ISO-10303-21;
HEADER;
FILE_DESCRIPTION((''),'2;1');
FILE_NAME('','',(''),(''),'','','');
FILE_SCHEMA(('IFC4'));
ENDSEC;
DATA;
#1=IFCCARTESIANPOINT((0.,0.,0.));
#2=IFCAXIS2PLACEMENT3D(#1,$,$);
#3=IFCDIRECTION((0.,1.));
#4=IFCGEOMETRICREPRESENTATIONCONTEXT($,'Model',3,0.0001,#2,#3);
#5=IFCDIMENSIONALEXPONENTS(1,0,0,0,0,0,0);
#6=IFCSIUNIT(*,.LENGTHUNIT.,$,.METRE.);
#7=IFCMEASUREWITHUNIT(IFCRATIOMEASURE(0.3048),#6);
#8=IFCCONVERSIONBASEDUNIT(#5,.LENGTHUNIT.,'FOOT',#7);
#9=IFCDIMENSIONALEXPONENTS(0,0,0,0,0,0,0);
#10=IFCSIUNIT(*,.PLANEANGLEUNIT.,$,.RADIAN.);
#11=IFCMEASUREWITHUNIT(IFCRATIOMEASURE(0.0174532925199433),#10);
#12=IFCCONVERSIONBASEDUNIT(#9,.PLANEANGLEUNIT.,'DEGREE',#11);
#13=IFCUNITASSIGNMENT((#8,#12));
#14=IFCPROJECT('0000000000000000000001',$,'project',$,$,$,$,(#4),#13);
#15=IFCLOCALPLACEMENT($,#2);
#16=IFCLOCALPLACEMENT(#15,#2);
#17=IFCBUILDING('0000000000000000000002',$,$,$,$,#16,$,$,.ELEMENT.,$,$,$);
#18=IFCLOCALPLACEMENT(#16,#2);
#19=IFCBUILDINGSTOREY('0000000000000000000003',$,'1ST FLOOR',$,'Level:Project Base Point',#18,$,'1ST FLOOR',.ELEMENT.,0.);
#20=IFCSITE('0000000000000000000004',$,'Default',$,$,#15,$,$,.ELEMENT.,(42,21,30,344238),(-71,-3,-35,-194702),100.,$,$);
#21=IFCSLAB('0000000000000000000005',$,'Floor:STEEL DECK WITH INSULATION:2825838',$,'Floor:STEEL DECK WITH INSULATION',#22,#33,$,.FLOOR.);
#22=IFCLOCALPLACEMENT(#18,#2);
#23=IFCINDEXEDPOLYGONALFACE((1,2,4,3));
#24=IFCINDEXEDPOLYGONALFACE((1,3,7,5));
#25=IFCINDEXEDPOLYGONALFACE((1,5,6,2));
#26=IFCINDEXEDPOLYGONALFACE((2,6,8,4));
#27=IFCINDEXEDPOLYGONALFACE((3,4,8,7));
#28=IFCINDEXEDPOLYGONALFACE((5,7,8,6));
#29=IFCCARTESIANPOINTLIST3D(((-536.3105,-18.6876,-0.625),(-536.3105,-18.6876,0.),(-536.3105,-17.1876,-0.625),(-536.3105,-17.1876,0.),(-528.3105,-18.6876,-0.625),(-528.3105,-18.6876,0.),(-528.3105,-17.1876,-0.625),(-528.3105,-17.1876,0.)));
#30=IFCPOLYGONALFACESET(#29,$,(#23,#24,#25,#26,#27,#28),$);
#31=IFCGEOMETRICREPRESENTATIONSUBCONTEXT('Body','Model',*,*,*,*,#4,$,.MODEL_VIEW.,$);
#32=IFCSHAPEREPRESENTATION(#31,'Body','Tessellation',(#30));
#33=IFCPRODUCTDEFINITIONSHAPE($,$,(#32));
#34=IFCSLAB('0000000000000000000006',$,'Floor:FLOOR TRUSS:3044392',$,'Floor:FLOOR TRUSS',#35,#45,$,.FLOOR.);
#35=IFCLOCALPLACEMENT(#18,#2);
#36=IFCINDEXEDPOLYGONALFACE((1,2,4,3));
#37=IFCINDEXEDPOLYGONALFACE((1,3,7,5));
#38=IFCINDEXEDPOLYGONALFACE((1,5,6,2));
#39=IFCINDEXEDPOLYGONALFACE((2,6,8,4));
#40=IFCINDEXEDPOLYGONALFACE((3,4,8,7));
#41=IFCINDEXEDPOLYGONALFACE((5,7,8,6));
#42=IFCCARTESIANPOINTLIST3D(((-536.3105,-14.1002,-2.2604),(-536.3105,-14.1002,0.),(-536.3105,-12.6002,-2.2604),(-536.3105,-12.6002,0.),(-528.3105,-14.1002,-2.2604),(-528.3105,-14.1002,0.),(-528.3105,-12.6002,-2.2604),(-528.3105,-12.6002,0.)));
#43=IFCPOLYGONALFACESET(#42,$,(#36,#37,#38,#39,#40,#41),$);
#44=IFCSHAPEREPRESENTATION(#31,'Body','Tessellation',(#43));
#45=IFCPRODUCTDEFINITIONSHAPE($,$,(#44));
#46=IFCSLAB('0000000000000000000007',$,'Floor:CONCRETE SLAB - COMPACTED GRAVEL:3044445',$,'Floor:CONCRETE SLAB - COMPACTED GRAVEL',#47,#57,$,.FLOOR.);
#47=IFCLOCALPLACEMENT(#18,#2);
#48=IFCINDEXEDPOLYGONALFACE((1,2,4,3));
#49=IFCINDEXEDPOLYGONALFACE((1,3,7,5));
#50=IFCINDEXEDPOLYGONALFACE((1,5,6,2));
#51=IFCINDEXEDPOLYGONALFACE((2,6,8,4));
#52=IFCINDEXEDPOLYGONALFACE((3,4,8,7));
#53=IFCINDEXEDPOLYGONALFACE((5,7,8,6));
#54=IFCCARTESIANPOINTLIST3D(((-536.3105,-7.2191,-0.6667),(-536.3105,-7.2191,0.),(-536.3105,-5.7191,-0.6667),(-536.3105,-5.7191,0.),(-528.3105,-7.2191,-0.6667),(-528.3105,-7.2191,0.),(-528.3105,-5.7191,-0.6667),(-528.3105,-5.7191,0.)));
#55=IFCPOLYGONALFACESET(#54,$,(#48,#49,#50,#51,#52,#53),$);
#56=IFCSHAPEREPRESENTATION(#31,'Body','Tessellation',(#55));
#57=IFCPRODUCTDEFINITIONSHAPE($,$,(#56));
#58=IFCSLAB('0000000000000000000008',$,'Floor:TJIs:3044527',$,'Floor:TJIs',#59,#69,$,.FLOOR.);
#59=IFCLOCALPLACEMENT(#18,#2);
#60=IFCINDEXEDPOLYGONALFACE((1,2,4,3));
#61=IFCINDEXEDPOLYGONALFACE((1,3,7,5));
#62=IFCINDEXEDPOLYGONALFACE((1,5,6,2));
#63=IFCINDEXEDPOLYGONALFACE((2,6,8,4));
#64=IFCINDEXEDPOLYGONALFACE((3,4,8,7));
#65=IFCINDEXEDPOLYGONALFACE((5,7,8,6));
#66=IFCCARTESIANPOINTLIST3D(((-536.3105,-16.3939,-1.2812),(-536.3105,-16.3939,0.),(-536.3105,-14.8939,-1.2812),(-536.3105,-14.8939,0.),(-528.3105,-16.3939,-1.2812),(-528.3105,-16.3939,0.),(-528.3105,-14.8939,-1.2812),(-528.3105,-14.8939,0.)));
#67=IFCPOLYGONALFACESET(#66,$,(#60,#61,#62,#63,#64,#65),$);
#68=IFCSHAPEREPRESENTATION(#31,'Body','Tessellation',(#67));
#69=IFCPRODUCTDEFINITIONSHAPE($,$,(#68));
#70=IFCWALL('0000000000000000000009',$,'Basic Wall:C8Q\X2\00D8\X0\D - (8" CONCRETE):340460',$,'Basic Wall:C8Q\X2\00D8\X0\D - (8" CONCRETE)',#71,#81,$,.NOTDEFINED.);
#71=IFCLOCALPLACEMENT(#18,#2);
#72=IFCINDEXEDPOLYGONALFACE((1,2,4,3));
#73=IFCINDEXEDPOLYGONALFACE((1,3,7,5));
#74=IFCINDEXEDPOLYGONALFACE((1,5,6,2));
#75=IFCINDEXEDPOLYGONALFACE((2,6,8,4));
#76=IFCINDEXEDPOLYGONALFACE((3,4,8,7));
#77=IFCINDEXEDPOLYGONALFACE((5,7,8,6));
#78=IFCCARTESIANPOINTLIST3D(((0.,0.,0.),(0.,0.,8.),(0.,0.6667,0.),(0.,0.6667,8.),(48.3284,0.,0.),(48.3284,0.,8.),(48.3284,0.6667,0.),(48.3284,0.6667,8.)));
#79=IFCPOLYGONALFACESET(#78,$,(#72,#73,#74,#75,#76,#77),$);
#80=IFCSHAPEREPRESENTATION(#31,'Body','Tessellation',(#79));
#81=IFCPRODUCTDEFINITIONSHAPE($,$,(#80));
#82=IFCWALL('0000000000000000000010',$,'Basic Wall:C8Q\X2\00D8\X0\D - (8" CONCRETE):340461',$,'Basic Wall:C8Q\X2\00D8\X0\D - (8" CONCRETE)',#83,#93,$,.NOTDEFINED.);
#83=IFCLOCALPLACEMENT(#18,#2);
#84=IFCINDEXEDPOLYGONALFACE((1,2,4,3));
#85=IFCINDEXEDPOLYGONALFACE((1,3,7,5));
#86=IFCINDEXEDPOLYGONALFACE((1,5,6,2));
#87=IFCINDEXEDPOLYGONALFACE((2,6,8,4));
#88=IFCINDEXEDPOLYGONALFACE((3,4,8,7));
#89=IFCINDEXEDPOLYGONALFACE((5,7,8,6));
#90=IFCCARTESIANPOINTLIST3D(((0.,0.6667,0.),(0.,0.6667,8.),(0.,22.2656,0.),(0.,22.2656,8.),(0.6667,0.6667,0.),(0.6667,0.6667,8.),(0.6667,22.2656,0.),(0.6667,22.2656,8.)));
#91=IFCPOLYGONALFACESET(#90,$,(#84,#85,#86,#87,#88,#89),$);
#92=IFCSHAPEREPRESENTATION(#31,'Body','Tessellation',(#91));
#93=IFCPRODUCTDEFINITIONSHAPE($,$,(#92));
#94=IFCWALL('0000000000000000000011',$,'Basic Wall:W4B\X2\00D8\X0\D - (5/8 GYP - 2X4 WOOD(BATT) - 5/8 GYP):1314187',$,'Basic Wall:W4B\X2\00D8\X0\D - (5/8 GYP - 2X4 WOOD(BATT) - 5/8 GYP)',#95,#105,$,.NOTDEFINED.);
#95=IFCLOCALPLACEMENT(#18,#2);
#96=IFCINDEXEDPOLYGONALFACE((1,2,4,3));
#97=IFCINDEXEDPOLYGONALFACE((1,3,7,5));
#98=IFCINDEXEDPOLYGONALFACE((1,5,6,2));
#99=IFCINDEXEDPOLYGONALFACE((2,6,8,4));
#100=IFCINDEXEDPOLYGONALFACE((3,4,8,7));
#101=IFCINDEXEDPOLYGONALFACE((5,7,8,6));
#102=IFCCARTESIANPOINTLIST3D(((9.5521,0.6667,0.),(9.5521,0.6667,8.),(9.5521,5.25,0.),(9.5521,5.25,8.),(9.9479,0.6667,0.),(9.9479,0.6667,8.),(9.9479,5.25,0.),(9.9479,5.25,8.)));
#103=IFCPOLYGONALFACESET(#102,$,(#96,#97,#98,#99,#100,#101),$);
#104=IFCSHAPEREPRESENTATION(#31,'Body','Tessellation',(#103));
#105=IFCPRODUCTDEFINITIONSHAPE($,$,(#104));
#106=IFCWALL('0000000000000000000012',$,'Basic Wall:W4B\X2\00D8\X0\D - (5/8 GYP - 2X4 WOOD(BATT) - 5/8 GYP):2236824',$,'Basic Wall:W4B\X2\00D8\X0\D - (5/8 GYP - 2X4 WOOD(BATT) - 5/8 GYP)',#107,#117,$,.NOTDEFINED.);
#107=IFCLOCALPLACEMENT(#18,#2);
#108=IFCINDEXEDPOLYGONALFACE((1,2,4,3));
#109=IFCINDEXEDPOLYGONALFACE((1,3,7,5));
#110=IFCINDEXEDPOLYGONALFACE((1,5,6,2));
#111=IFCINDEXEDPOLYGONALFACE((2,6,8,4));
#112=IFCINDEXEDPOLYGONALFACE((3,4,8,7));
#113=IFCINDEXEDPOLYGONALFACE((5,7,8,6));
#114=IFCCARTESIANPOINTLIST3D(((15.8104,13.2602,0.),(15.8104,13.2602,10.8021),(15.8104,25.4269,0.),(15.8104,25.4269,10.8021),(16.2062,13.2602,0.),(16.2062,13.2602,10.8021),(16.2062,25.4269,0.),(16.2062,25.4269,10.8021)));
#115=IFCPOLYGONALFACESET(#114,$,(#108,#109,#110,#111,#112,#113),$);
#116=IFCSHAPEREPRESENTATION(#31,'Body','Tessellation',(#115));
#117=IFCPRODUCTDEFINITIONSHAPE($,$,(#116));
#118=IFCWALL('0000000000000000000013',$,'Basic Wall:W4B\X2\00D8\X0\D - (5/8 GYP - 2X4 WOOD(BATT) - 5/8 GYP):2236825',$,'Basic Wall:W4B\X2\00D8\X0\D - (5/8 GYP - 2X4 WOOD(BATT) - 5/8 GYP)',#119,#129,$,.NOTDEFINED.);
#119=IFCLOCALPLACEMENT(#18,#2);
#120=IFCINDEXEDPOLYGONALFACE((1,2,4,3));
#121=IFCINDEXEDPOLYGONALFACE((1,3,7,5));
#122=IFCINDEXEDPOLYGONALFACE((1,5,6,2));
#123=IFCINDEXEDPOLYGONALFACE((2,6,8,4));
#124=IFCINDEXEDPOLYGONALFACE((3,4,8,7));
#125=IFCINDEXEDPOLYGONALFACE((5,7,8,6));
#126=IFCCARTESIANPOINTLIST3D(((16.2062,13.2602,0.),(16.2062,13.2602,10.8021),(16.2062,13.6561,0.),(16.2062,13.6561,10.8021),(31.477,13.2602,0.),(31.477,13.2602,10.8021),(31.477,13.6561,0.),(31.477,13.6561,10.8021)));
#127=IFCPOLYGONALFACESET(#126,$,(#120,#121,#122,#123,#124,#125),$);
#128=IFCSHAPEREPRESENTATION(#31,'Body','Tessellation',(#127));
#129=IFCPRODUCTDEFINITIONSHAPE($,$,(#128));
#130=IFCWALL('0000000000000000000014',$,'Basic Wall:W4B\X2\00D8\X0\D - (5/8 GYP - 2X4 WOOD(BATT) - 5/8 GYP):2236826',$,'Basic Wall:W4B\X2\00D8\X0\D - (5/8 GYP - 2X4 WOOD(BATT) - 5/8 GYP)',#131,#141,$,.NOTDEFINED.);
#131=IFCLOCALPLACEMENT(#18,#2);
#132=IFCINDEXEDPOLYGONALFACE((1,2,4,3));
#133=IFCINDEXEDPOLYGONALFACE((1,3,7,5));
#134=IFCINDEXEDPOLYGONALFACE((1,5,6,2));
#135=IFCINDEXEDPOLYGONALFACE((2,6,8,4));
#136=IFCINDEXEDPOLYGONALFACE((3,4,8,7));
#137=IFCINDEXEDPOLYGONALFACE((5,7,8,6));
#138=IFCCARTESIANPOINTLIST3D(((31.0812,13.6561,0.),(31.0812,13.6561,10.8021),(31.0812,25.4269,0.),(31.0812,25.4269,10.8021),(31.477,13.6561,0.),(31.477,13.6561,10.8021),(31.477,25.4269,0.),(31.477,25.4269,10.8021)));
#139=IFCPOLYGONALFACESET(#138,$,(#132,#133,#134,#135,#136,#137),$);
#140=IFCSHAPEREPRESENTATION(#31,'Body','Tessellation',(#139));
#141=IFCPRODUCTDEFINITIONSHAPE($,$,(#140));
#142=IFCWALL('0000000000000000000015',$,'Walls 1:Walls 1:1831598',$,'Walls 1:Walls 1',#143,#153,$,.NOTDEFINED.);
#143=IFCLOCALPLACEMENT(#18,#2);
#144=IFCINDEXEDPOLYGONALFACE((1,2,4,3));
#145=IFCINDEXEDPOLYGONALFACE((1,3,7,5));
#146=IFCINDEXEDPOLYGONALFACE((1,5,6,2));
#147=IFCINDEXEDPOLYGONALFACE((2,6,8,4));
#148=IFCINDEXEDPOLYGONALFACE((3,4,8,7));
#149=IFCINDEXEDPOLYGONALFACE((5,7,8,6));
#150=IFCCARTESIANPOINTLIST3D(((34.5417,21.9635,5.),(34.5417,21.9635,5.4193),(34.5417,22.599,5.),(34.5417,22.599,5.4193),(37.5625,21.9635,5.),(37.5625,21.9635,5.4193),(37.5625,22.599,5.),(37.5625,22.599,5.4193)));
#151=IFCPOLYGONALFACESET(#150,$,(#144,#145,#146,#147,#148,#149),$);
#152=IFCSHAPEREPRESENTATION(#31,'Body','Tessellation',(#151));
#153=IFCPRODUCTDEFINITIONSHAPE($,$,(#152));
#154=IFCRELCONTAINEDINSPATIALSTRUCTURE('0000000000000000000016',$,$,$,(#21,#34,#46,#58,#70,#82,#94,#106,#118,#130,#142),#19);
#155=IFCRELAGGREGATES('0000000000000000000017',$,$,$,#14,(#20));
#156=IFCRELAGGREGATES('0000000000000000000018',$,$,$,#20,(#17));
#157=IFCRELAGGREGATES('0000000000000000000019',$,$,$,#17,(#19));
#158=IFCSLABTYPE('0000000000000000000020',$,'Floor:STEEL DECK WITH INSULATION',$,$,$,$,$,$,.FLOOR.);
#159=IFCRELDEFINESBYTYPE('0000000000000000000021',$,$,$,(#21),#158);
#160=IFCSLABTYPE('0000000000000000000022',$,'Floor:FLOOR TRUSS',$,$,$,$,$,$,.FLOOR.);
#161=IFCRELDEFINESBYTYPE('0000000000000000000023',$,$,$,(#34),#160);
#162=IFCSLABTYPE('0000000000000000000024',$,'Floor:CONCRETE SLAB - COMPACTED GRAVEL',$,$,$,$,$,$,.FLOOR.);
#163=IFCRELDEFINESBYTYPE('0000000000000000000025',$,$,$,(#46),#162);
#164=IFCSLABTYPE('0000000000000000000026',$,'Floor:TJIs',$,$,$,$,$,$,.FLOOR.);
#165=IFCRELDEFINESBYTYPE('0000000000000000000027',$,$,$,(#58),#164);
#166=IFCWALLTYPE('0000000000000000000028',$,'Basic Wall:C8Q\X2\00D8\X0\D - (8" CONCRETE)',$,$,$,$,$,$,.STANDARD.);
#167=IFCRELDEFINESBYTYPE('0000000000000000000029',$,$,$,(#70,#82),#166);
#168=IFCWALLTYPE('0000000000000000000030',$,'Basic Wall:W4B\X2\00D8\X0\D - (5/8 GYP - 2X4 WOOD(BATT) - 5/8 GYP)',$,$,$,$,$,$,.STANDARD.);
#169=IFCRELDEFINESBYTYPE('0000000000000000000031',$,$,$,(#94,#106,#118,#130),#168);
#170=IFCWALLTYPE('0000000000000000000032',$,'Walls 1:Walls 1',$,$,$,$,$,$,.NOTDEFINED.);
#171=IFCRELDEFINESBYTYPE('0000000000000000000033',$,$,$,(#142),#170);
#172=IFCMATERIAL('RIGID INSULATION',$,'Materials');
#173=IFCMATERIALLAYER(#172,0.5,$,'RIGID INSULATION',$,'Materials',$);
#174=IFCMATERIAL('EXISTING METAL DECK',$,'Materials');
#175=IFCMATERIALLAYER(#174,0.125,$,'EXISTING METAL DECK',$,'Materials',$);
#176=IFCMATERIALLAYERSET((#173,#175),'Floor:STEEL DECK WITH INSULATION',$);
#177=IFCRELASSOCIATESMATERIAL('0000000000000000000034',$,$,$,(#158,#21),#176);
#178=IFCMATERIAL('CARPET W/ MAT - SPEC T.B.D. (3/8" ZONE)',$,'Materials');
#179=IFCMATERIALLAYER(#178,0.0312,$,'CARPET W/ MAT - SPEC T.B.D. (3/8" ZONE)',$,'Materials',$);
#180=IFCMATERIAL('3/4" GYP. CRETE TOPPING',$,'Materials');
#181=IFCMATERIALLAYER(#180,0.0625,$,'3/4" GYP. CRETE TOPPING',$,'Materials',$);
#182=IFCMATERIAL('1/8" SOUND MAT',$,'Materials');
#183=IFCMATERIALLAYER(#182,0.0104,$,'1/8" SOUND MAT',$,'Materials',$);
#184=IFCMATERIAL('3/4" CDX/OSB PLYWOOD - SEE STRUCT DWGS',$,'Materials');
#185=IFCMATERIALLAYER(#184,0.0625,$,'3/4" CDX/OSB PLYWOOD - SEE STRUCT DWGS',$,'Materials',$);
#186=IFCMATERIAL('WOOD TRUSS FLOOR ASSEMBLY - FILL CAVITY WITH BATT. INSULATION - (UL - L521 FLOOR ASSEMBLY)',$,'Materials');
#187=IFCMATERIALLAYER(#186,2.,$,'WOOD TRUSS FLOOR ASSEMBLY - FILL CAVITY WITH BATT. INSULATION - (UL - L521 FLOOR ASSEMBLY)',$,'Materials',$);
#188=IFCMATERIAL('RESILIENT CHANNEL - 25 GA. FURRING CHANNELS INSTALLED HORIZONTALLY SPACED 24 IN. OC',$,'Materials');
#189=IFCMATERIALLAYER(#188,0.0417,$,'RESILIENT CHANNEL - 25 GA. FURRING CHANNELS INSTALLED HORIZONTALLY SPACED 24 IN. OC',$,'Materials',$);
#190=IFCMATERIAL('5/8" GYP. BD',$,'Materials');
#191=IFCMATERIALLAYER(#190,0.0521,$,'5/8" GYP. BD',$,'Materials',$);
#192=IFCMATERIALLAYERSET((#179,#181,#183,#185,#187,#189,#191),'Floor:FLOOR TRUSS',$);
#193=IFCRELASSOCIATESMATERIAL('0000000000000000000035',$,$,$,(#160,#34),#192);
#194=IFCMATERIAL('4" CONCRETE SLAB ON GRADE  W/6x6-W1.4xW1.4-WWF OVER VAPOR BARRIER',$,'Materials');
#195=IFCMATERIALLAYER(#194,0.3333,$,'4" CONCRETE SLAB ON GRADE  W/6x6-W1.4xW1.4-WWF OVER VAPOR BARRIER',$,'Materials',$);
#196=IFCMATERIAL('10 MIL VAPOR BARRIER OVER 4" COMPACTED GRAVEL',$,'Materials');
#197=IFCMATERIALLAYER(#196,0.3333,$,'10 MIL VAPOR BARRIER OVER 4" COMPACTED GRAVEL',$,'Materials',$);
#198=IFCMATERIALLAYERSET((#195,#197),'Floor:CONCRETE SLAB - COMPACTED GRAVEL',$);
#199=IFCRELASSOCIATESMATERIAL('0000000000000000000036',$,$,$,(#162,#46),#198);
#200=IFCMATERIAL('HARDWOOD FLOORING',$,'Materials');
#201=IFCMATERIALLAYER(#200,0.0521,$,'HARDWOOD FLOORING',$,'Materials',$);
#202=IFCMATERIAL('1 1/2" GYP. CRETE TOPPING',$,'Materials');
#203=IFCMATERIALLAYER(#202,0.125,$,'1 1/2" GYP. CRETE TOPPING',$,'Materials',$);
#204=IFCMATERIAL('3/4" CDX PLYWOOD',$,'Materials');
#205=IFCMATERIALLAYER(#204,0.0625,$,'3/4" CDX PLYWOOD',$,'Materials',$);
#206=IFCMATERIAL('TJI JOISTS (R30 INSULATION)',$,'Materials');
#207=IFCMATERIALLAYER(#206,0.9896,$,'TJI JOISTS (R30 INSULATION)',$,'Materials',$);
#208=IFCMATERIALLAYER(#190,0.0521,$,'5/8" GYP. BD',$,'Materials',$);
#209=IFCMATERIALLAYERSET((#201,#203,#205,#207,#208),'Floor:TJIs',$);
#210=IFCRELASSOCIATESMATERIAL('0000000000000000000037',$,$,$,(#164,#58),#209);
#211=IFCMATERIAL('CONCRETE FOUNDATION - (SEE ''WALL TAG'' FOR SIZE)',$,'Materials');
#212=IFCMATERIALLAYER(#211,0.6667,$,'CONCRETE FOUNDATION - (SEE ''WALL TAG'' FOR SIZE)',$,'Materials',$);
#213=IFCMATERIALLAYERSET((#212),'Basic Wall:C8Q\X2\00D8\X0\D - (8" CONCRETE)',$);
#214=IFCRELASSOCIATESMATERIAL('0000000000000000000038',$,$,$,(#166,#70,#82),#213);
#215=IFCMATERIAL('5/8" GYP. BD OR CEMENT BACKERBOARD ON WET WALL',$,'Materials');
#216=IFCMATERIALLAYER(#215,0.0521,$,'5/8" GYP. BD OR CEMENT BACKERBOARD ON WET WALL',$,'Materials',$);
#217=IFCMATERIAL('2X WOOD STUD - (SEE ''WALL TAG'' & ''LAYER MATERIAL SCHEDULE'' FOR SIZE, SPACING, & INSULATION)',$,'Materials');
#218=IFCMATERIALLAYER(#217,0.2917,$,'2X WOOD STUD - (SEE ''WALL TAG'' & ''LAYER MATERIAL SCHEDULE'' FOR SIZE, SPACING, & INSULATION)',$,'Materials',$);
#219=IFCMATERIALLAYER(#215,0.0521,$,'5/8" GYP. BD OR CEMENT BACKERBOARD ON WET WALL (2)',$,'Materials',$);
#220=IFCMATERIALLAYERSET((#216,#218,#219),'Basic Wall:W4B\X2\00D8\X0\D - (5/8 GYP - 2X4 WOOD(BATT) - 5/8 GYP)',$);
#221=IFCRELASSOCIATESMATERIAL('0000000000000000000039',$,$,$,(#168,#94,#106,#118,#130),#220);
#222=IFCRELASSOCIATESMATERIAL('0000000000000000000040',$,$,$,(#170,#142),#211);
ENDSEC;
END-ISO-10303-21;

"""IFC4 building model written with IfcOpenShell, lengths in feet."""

from ifc_helpers import new_model, entity, si_unit, converted_unit, direction, frame, frame_2d, origin, origin_2d_with_axis, place, context, subcontext, project, spatial, rectangle, extrude, material, layer, layer_set, layer_usage, type_object, element, save


model = new_model("IFC4")

# Units and contexts
model_context = context("Model", 3, precision=0.0001, world=origin(), true_north=direction((0.0, 1.0)))
body_context = subcontext(model_context, "Body", "Model", "MODEL_VIEW")
ifc_project = project(units=[converted_unit("LENGTHUNIT", "FOOT", entity("IfcRatioMeasure", 0.3048), si_unit("LENGTHUNIT", "METRE"), dimensions=[1, 0, 0, 0, 0, 0, 0]), converted_unit("PLANEANGLEUNIT", "DEGREE", entity("IfcRatioMeasure", 0.0174532925199433), si_unit("PLANEANGLEUNIT", "RADIAN"), dimensions=[0, 0, 0, 0, 0, 0, 0])], contexts=[model_context])

# Site, building, storey
site_placement = place(None, origin())
site = spatial("IfcSite", under=ifc_project, at=site_placement, Name="Default", CompositionType="ELEMENT", RefLatitude=(42, 21, 30, 344238), RefLongitude=(-71, -3, -35, -194702), RefElevation=100.0)
building_placement = place(site_placement, origin())
building = spatial("IfcBuilding", under=site, at=building_placement, CompositionType="ELEMENT")
storey_placement = place(building_placement, origin())
storey = spatial("IfcBuildingStorey", under=building, at=storey_placement, Name="1ST FLOOR", ObjectType="Level:Project Base Point", LongName="1ST FLOOR", CompositionType="ELEMENT", Elevation=0.0)

# Slabs
ifc_material_1 = material(Name="RIGID INSULATION", Category="Materials")
ifc_layer_1 = layer(ifc_material_1, 0.5, Name="RIGID INSULATION", Category="Materials")
ifc_material_2 = material(Name="EXISTING METAL DECK", Category="Materials")
ifc_layer_2 = layer(ifc_material_2, 0.125, Name="EXISTING METAL DECK", Category="Materials")
ifc_layer_set_1 = layer_set([ifc_layer_1, ifc_layer_2], Name="Floor:STEEL DECK WITH INSULATION")
ifc_layer_usage_1 = layer_usage(ifc_layer_set_1, "AXIS3", "POSITIVE", 0.0)
slab_type_1 = type_object("IfcSlabType", Name="Floor:STEEL DECK WITH INSULATION", PredefinedType="FLOOR", material=ifc_layer_set_1)
slab_1_placement = place(storey_placement, origin())
element("IfcSlab", 1, at=slab_1_placement, inside=storey, type_object=slab_type_1, material=ifc_layer_usage_1, Name="Floor:STEEL DECK WITH INSULATION:2825838", ObjectType="Floor:STEEL DECK WITH INSULATION", PredefinedType="FLOOR", context=body_context, shape_type="SweptSolid", body=[
    extrude(rectangle(XDim=1.5, YDim=8.0, at=origin_2d_with_axis()), frame((-532.3105, -17.9376, 0.0), z_axis=(0.0, 0.0, -1.0), x_axis=(0.0, 1.0, 0.0)), (0.0, 0.0, 1.0), 0.625),
])
ifc_material_3 = material(Name="CARPET W/ MAT - SPEC T.B.D. (3/8\" ZONE)", Category="Materials")
ifc_layer_3 = layer(ifc_material_3, 0.0312, Name="CARPET W/ MAT - SPEC T.B.D. (3/8\" ZONE)", Category="Materials")
ifc_material_4 = material(Name="3/4\" GYP. CRETE TOPPING", Category="Materials")
ifc_layer_4 = layer(ifc_material_4, 0.0625, Name="3/4\" GYP. CRETE TOPPING", Category="Materials")
ifc_material_5 = material(Name="1/8\" SOUND MAT", Category="Materials")
ifc_layer_5 = layer(ifc_material_5, 0.0104, Name="1/8\" SOUND MAT", Category="Materials")
ifc_material_6 = material(Name="3/4\" CDX/OSB PLYWOOD - SEE STRUCT DWGS", Category="Materials")
ifc_layer_6 = layer(ifc_material_6, 0.0625, Name="3/4\" CDX/OSB PLYWOOD - SEE STRUCT DWGS", Category="Materials")
ifc_material_7 = material(Name="WOOD TRUSS FLOOR ASSEMBLY - FILL CAVITY WITH BATT. INSULATION - (UL - L521 FLOOR ASSEMBLY)", Category="Materials")
ifc_layer_7 = layer(ifc_material_7, 2.0, Name="WOOD TRUSS FLOOR ASSEMBLY - FILL CAVITY WITH BATT. INSULATION - (UL - L521 FLOOR ASSEMBLY)", Category="Materials")
ifc_material_8 = material(Name="RESILIENT CHANNEL - 25 GA. FURRING CHANNELS INSTALLED HORIZONTALLY SPACED 24 IN. OC", Category="Materials")
ifc_layer_8 = layer(ifc_material_8, 0.0417, Name="RESILIENT CHANNEL - 25 GA. FURRING CHANNELS INSTALLED HORIZONTALLY SPACED 24 IN. OC", Category="Materials")
ifc_material_9 = material(Name="5/8\" GYP. BD", Category="Materials")
ifc_layer_9 = layer(ifc_material_9, 0.0521, Name="5/8\" GYP. BD", Category="Materials")
ifc_layer_set_2 = layer_set([ifc_layer_3, ifc_layer_4, ifc_layer_5, ifc_layer_6, ifc_layer_7, ifc_layer_8, ifc_layer_9], Name="Floor:FLOOR TRUSS")
ifc_layer_usage_2 = layer_usage(ifc_layer_set_2, "AXIS3", "POSITIVE", 0.0)
slab_type_2 = type_object("IfcSlabType", Name="Floor:FLOOR TRUSS", PredefinedType="FLOOR", material=ifc_layer_set_2)
slab_2_placement = place(storey_placement, origin())
element("IfcSlab", 2, at=slab_2_placement, inside=storey, type_object=slab_type_2, material=ifc_layer_usage_2, Name="Floor:FLOOR TRUSS:3044392", ObjectType="Floor:FLOOR TRUSS", PredefinedType="FLOOR", context=body_context, shape_type="SweptSolid", body=[
    extrude(rectangle(XDim=1.5, YDim=8.0, at=origin_2d_with_axis()), frame((-532.3105, -13.3502, 0.0), z_axis=(0.0, 0.0, -1.0), x_axis=(0.0, 1.0, 0.0)), (0.0, 0.0, 1.0), 2.2604),
])
ifc_material_10 = material(Name="4\" CONCRETE SLAB ON GRADE  W/6x6-W1.4xW1.4-WWF OVER VAPOR BARRIER", Category="Materials")
ifc_layer_10 = layer(ifc_material_10, 0.3333, Name="4\" CONCRETE SLAB ON GRADE  W/6x6-W1.4xW1.4-WWF OVER VAPOR BARRIER", Category="Materials")
ifc_material_11 = material(Name="10 MIL VAPOR BARRIER OVER 4\" COMPACTED GRAVEL", Category="Materials")
ifc_layer_11 = layer(ifc_material_11, 0.3333, Name="10 MIL VAPOR BARRIER OVER 4\" COMPACTED GRAVEL", Category="Materials")
ifc_layer_set_3 = layer_set([ifc_layer_10, ifc_layer_11], Name="Floor:CONCRETE SLAB - COMPACTED GRAVEL")
ifc_layer_usage_3 = layer_usage(ifc_layer_set_3, "AXIS3", "POSITIVE", 0.0)
slab_type_3 = type_object("IfcSlabType", Name="Floor:CONCRETE SLAB - COMPACTED GRAVEL", PredefinedType="FLOOR", material=ifc_layer_set_3)
slab_3_placement = place(storey_placement, origin())
element("IfcSlab", 3, at=slab_3_placement, inside=storey, type_object=slab_type_3, material=ifc_layer_usage_3, Name="Floor:CONCRETE SLAB - COMPACTED GRAVEL:3044445", ObjectType="Floor:CONCRETE SLAB - COMPACTED GRAVEL", PredefinedType="FLOOR", context=body_context, shape_type="SweptSolid", body=[
    extrude(rectangle(XDim=1.5, YDim=8.0, at=origin_2d_with_axis()), frame((-532.3105, -6.4691, 0.0), z_axis=(0.0, 0.0, -1.0), x_axis=(0.0, 1.0, 0.0)), (0.0, 0.0, 1.0), 0.6667),
])
ifc_material_12 = material(Name="HARDWOOD FLOORING", Category="Materials")
ifc_layer_12 = layer(ifc_material_12, 0.0521, Name="HARDWOOD FLOORING", Category="Materials")
ifc_material_13 = material(Name="1 1/2\" GYP. CRETE TOPPING", Category="Materials")
ifc_layer_13 = layer(ifc_material_13, 0.125, Name="1 1/2\" GYP. CRETE TOPPING", Category="Materials")
ifc_material_14 = material(Name="3/4\" CDX PLYWOOD", Category="Materials")
ifc_layer_14 = layer(ifc_material_14, 0.0625, Name="3/4\" CDX PLYWOOD", Category="Materials")
ifc_material_15 = material(Name="TJI JOISTS (R30 INSULATION)", Category="Materials")
ifc_layer_15 = layer(ifc_material_15, 0.9896, Name="TJI JOISTS (R30 INSULATION)", Category="Materials")
ifc_layer_16 = layer(ifc_material_9, 0.0521, Name="5/8\" GYP. BD", Category="Materials")
ifc_layer_set_4 = layer_set([ifc_layer_12, ifc_layer_13, ifc_layer_14, ifc_layer_15, ifc_layer_16], Name="Floor:TJIs")
ifc_layer_usage_4 = layer_usage(ifc_layer_set_4, "AXIS3", "POSITIVE", 0.0)
slab_type_4 = type_object("IfcSlabType", Name="Floor:TJIs", PredefinedType="FLOOR", material=ifc_layer_set_4)
slab_4_placement = place(storey_placement, origin())
element("IfcSlab", 4, at=slab_4_placement, inside=storey, type_object=slab_type_4, material=ifc_layer_usage_4, Name="Floor:TJIs:3044527", ObjectType="Floor:TJIs", PredefinedType="FLOOR", context=body_context, shape_type="SweptSolid", body=[
    extrude(rectangle(XDim=1.5, YDim=8.0, at=frame_2d((0.0, 0.0), x_axis=(1.0, 0.0))), frame((-532.3105, -15.6439, 0.0), z_axis=(0.0, 0.0, -1.0), x_axis=(0.0, 1.0, 0.0)), (0.0, 0.0, 1.0), 1.2812),
])

# Walls
ifc_material_16 = material(Name="CONCRETE FOUNDATION - (SEE 'WALL TAG' FOR SIZE)", Category="Materials")
ifc_layer_17 = layer(ifc_material_16, 0.6667, Name="CONCRETE FOUNDATION - (SEE 'WALL TAG' FOR SIZE)", Category="Materials")
ifc_layer_set_5 = layer_set([ifc_layer_17], Name="Basic Wall:C8QØD - (8\" CONCRETE)")
ifc_layer_usage_5 = layer_usage(ifc_layer_set_5, "AXIS2", "POSITIVE", -0.3333)
wall_type_1 = type_object("IfcWallType", Name="Basic Wall:C8QØD - (8\" CONCRETE)", PredefinedType="STANDARD", material=ifc_layer_set_5)
wall_1_placement = place(storey_placement, frame((0.0, 0.3333, 0.0)))
element("IfcWall", 5, at=wall_1_placement, inside=storey, type_object=wall_type_1, material=ifc_layer_usage_5, Name="Basic Wall:C8QØD - (8\" CONCRETE):340460", ObjectType="Basic Wall:C8QØD - (8\" CONCRETE)", PredefinedType="NOTDEFINED", context=body_context, shape_type="SweptSolid", body=[
    extrude(rectangle(XDim=48.3284, YDim=0.6667, at=frame_2d((24.1642, 0.0), x_axis=(-1.0, 0.0))), origin(), (0.0, 0.0, 1.0), 8.0),
])
ifc_layer_usage_6 = layer_usage(ifc_layer_set_5, "AXIS2", "POSITIVE", -0.3333)
wall_2_placement = place(storey_placement, frame((0.3333, 22.2656, 0.0), z_axis=(0.0, 0.0, 1.0), x_axis=(0.0, -1.0, 0.0)))
element("IfcWall", 6, at=wall_2_placement, inside=storey, type_object=wall_type_1, material=ifc_layer_usage_6, Name="Basic Wall:C8QØD - (8\" CONCRETE):340461", ObjectType="Basic Wall:C8QØD - (8\" CONCRETE)", PredefinedType="NOTDEFINED", context=body_context, shape_type="SweptSolid", body=[
    extrude(rectangle(XDim=21.599, YDim=0.6667, at=frame_2d((10.7995, 0.0), x_axis=(-1.0, 0.0))), origin(), (0.0, 0.0, 1.0), 8.0),
])
ifc_material_17 = material(Name="5/8\" GYP. BD OR CEMENT BACKERBOARD ON WET WALL", Category="Materials")
ifc_layer_18 = layer(ifc_material_17, 0.0521, Name="5/8\" GYP. BD OR CEMENT BACKERBOARD ON WET WALL", Category="Materials")
ifc_material_18 = material(Name="2X WOOD STUD - (SEE 'WALL TAG' & 'LAYER MATERIAL SCHEDULE' FOR SIZE, SPACING, & INSULATION)", Category="Materials")
ifc_layer_19 = layer(ifc_material_18, 0.2917, Name="2X WOOD STUD - (SEE 'WALL TAG' & 'LAYER MATERIAL SCHEDULE' FOR SIZE, SPACING, & INSULATION)", Category="Materials")
ifc_layer_20 = layer(ifc_material_17, 0.0521, Name="5/8\" GYP. BD OR CEMENT BACKERBOARD ON WET WALL (2)", Category="Materials")
ifc_layer_set_6 = layer_set([ifc_layer_18, ifc_layer_19, ifc_layer_20], Name="Basic Wall:W4BØD - (5/8 GYP - 2X4 WOOD(BATT) - 5/8 GYP)")
ifc_layer_usage_7 = layer_usage(ifc_layer_set_6, "AXIS2", "NEGATIVE", 0.1979)
wall_type_2 = type_object("IfcWallType", Name="Basic Wall:W4BØD - (5/8 GYP - 2X4 WOOD(BATT) - 5/8 GYP)", PredefinedType="STANDARD", material=ifc_layer_set_6)
wall_3_placement = place(storey_placement, frame((9.75, 5.25, 0.0), z_axis=(0.0, 0.0, 1.0), x_axis=(0.0, -1.0, 0.0)))
element("IfcWall", 7, at=wall_3_placement, inside=storey, type_object=wall_type_2, material=ifc_layer_usage_7, Name="Basic Wall:W4BØD - (5/8 GYP - 2X4 WOOD(BATT) - 5/8 GYP):1314187", ObjectType="Basic Wall:W4BØD - (5/8 GYP - 2X4 WOOD(BATT) - 5/8 GYP)", PredefinedType="NOTDEFINED", context=body_context, shape_type="SweptSolid", body=[
    extrude(rectangle(XDim=4.5833, YDim=0.3958, at=frame_2d((2.2917, 0.0), x_axis=(-1.0, 0.0))), origin(), (0.0, 0.0, 1.0), 8.0),
])
ifc_layer_usage_8 = layer_usage(ifc_layer_set_6, "AXIS2", "NEGATIVE", 0.1979)
wall_4_placement = place(storey_placement, frame((16.0083, 13.2602, 0.0), z_axis=(0.0, 0.0, 1.0), x_axis=(0.0, 1.0, 0.0)))
element("IfcWall", 8, at=wall_4_placement, inside=storey, type_object=wall_type_2, material=ifc_layer_usage_8, Name="Basic Wall:W4BØD - (5/8 GYP - 2X4 WOOD(BATT) - 5/8 GYP):2236824", ObjectType="Basic Wall:W4BØD - (5/8 GYP - 2X4 WOOD(BATT) - 5/8 GYP)", PredefinedType="NOTDEFINED", context=body_context, shape_type="SweptSolid", body=[
    extrude(rectangle(XDim=12.1667, YDim=0.3958, at=frame_2d((6.0833, 0.0), x_axis=(-1.0, 0.0))), origin(), (0.0, 0.0, 1.0), 10.8021),
])
ifc_layer_usage_9 = layer_usage(ifc_layer_set_6, "AXIS2", "NEGATIVE", 0.1979)
wall_5_placement = place(storey_placement, frame((31.477, 13.4581, 0.0), z_axis=(0.0, 0.0, 1.0), x_axis=(-1.0, 0.0, 0.0)))
element("IfcWall", 9, at=wall_5_placement, inside=storey, type_object=wall_type_2, material=ifc_layer_usage_9, Name="Basic Wall:W4BØD - (5/8 GYP - 2X4 WOOD(BATT) - 5/8 GYP):2236825", ObjectType="Basic Wall:W4BØD - (5/8 GYP - 2X4 WOOD(BATT) - 5/8 GYP)", PredefinedType="NOTDEFINED", context=body_context, shape_type="SweptSolid", body=[
    extrude(rectangle(XDim=15.2708, YDim=0.3958, at=frame_2d((7.6354, 0.0), x_axis=(-1.0, 0.0))), origin(), (0.0, 0.0, 1.0), 10.8021),
])
ifc_layer_usage_10 = layer_usage(ifc_layer_set_6, "AXIS2", "NEGATIVE", 0.1979)
wall_6_placement = place(storey_placement, frame((31.2791, 25.4269, 0.0), z_axis=(0.0, 0.0, 1.0), x_axis=(0.0, -1.0, 0.0)))
element("IfcWall", 10, at=wall_6_placement, inside=storey, type_object=wall_type_2, material=ifc_layer_usage_10, Name="Basic Wall:W4BØD - (5/8 GYP - 2X4 WOOD(BATT) - 5/8 GYP):2236826", ObjectType="Basic Wall:W4BØD - (5/8 GYP - 2X4 WOOD(BATT) - 5/8 GYP)", PredefinedType="NOTDEFINED", context=body_context, shape_type="SweptSolid", body=[
    extrude(rectangle(XDim=11.7708, YDim=0.3958, at=frame_2d((5.8854, 0.0), x_axis=(-1.0, 0.0))), origin(), (0.0, 0.0, 1.0), 10.8021),
])
wall_type_3 = type_object("IfcWallType", Name="Walls 1:Walls 1", PredefinedType="NOTDEFINED", material=ifc_material_16)
wall_7_placement = place(storey_placement, frame((34.5417, 21.9635, 5.0)))
element("IfcWall", 11, at=wall_7_placement, inside=storey, type_object=wall_type_3, material=ifc_material_16, Name="Walls 1:Walls 1:1831598", ObjectType="Walls 1:Walls 1", PredefinedType="NOTDEFINED", context=body_context, shape_type="SweptSolid", body=[
    extrude(rectangle(XDim=3.0208, YDim=0.6354, at=frame_2d((0.0, 0.0), x_axis=(1.0, 0.0))), frame((1.5104, 0.3177, 0.0)), (0.0, 0.0, 1.0), 0.4193),
])

save(model, "model.ifc")
